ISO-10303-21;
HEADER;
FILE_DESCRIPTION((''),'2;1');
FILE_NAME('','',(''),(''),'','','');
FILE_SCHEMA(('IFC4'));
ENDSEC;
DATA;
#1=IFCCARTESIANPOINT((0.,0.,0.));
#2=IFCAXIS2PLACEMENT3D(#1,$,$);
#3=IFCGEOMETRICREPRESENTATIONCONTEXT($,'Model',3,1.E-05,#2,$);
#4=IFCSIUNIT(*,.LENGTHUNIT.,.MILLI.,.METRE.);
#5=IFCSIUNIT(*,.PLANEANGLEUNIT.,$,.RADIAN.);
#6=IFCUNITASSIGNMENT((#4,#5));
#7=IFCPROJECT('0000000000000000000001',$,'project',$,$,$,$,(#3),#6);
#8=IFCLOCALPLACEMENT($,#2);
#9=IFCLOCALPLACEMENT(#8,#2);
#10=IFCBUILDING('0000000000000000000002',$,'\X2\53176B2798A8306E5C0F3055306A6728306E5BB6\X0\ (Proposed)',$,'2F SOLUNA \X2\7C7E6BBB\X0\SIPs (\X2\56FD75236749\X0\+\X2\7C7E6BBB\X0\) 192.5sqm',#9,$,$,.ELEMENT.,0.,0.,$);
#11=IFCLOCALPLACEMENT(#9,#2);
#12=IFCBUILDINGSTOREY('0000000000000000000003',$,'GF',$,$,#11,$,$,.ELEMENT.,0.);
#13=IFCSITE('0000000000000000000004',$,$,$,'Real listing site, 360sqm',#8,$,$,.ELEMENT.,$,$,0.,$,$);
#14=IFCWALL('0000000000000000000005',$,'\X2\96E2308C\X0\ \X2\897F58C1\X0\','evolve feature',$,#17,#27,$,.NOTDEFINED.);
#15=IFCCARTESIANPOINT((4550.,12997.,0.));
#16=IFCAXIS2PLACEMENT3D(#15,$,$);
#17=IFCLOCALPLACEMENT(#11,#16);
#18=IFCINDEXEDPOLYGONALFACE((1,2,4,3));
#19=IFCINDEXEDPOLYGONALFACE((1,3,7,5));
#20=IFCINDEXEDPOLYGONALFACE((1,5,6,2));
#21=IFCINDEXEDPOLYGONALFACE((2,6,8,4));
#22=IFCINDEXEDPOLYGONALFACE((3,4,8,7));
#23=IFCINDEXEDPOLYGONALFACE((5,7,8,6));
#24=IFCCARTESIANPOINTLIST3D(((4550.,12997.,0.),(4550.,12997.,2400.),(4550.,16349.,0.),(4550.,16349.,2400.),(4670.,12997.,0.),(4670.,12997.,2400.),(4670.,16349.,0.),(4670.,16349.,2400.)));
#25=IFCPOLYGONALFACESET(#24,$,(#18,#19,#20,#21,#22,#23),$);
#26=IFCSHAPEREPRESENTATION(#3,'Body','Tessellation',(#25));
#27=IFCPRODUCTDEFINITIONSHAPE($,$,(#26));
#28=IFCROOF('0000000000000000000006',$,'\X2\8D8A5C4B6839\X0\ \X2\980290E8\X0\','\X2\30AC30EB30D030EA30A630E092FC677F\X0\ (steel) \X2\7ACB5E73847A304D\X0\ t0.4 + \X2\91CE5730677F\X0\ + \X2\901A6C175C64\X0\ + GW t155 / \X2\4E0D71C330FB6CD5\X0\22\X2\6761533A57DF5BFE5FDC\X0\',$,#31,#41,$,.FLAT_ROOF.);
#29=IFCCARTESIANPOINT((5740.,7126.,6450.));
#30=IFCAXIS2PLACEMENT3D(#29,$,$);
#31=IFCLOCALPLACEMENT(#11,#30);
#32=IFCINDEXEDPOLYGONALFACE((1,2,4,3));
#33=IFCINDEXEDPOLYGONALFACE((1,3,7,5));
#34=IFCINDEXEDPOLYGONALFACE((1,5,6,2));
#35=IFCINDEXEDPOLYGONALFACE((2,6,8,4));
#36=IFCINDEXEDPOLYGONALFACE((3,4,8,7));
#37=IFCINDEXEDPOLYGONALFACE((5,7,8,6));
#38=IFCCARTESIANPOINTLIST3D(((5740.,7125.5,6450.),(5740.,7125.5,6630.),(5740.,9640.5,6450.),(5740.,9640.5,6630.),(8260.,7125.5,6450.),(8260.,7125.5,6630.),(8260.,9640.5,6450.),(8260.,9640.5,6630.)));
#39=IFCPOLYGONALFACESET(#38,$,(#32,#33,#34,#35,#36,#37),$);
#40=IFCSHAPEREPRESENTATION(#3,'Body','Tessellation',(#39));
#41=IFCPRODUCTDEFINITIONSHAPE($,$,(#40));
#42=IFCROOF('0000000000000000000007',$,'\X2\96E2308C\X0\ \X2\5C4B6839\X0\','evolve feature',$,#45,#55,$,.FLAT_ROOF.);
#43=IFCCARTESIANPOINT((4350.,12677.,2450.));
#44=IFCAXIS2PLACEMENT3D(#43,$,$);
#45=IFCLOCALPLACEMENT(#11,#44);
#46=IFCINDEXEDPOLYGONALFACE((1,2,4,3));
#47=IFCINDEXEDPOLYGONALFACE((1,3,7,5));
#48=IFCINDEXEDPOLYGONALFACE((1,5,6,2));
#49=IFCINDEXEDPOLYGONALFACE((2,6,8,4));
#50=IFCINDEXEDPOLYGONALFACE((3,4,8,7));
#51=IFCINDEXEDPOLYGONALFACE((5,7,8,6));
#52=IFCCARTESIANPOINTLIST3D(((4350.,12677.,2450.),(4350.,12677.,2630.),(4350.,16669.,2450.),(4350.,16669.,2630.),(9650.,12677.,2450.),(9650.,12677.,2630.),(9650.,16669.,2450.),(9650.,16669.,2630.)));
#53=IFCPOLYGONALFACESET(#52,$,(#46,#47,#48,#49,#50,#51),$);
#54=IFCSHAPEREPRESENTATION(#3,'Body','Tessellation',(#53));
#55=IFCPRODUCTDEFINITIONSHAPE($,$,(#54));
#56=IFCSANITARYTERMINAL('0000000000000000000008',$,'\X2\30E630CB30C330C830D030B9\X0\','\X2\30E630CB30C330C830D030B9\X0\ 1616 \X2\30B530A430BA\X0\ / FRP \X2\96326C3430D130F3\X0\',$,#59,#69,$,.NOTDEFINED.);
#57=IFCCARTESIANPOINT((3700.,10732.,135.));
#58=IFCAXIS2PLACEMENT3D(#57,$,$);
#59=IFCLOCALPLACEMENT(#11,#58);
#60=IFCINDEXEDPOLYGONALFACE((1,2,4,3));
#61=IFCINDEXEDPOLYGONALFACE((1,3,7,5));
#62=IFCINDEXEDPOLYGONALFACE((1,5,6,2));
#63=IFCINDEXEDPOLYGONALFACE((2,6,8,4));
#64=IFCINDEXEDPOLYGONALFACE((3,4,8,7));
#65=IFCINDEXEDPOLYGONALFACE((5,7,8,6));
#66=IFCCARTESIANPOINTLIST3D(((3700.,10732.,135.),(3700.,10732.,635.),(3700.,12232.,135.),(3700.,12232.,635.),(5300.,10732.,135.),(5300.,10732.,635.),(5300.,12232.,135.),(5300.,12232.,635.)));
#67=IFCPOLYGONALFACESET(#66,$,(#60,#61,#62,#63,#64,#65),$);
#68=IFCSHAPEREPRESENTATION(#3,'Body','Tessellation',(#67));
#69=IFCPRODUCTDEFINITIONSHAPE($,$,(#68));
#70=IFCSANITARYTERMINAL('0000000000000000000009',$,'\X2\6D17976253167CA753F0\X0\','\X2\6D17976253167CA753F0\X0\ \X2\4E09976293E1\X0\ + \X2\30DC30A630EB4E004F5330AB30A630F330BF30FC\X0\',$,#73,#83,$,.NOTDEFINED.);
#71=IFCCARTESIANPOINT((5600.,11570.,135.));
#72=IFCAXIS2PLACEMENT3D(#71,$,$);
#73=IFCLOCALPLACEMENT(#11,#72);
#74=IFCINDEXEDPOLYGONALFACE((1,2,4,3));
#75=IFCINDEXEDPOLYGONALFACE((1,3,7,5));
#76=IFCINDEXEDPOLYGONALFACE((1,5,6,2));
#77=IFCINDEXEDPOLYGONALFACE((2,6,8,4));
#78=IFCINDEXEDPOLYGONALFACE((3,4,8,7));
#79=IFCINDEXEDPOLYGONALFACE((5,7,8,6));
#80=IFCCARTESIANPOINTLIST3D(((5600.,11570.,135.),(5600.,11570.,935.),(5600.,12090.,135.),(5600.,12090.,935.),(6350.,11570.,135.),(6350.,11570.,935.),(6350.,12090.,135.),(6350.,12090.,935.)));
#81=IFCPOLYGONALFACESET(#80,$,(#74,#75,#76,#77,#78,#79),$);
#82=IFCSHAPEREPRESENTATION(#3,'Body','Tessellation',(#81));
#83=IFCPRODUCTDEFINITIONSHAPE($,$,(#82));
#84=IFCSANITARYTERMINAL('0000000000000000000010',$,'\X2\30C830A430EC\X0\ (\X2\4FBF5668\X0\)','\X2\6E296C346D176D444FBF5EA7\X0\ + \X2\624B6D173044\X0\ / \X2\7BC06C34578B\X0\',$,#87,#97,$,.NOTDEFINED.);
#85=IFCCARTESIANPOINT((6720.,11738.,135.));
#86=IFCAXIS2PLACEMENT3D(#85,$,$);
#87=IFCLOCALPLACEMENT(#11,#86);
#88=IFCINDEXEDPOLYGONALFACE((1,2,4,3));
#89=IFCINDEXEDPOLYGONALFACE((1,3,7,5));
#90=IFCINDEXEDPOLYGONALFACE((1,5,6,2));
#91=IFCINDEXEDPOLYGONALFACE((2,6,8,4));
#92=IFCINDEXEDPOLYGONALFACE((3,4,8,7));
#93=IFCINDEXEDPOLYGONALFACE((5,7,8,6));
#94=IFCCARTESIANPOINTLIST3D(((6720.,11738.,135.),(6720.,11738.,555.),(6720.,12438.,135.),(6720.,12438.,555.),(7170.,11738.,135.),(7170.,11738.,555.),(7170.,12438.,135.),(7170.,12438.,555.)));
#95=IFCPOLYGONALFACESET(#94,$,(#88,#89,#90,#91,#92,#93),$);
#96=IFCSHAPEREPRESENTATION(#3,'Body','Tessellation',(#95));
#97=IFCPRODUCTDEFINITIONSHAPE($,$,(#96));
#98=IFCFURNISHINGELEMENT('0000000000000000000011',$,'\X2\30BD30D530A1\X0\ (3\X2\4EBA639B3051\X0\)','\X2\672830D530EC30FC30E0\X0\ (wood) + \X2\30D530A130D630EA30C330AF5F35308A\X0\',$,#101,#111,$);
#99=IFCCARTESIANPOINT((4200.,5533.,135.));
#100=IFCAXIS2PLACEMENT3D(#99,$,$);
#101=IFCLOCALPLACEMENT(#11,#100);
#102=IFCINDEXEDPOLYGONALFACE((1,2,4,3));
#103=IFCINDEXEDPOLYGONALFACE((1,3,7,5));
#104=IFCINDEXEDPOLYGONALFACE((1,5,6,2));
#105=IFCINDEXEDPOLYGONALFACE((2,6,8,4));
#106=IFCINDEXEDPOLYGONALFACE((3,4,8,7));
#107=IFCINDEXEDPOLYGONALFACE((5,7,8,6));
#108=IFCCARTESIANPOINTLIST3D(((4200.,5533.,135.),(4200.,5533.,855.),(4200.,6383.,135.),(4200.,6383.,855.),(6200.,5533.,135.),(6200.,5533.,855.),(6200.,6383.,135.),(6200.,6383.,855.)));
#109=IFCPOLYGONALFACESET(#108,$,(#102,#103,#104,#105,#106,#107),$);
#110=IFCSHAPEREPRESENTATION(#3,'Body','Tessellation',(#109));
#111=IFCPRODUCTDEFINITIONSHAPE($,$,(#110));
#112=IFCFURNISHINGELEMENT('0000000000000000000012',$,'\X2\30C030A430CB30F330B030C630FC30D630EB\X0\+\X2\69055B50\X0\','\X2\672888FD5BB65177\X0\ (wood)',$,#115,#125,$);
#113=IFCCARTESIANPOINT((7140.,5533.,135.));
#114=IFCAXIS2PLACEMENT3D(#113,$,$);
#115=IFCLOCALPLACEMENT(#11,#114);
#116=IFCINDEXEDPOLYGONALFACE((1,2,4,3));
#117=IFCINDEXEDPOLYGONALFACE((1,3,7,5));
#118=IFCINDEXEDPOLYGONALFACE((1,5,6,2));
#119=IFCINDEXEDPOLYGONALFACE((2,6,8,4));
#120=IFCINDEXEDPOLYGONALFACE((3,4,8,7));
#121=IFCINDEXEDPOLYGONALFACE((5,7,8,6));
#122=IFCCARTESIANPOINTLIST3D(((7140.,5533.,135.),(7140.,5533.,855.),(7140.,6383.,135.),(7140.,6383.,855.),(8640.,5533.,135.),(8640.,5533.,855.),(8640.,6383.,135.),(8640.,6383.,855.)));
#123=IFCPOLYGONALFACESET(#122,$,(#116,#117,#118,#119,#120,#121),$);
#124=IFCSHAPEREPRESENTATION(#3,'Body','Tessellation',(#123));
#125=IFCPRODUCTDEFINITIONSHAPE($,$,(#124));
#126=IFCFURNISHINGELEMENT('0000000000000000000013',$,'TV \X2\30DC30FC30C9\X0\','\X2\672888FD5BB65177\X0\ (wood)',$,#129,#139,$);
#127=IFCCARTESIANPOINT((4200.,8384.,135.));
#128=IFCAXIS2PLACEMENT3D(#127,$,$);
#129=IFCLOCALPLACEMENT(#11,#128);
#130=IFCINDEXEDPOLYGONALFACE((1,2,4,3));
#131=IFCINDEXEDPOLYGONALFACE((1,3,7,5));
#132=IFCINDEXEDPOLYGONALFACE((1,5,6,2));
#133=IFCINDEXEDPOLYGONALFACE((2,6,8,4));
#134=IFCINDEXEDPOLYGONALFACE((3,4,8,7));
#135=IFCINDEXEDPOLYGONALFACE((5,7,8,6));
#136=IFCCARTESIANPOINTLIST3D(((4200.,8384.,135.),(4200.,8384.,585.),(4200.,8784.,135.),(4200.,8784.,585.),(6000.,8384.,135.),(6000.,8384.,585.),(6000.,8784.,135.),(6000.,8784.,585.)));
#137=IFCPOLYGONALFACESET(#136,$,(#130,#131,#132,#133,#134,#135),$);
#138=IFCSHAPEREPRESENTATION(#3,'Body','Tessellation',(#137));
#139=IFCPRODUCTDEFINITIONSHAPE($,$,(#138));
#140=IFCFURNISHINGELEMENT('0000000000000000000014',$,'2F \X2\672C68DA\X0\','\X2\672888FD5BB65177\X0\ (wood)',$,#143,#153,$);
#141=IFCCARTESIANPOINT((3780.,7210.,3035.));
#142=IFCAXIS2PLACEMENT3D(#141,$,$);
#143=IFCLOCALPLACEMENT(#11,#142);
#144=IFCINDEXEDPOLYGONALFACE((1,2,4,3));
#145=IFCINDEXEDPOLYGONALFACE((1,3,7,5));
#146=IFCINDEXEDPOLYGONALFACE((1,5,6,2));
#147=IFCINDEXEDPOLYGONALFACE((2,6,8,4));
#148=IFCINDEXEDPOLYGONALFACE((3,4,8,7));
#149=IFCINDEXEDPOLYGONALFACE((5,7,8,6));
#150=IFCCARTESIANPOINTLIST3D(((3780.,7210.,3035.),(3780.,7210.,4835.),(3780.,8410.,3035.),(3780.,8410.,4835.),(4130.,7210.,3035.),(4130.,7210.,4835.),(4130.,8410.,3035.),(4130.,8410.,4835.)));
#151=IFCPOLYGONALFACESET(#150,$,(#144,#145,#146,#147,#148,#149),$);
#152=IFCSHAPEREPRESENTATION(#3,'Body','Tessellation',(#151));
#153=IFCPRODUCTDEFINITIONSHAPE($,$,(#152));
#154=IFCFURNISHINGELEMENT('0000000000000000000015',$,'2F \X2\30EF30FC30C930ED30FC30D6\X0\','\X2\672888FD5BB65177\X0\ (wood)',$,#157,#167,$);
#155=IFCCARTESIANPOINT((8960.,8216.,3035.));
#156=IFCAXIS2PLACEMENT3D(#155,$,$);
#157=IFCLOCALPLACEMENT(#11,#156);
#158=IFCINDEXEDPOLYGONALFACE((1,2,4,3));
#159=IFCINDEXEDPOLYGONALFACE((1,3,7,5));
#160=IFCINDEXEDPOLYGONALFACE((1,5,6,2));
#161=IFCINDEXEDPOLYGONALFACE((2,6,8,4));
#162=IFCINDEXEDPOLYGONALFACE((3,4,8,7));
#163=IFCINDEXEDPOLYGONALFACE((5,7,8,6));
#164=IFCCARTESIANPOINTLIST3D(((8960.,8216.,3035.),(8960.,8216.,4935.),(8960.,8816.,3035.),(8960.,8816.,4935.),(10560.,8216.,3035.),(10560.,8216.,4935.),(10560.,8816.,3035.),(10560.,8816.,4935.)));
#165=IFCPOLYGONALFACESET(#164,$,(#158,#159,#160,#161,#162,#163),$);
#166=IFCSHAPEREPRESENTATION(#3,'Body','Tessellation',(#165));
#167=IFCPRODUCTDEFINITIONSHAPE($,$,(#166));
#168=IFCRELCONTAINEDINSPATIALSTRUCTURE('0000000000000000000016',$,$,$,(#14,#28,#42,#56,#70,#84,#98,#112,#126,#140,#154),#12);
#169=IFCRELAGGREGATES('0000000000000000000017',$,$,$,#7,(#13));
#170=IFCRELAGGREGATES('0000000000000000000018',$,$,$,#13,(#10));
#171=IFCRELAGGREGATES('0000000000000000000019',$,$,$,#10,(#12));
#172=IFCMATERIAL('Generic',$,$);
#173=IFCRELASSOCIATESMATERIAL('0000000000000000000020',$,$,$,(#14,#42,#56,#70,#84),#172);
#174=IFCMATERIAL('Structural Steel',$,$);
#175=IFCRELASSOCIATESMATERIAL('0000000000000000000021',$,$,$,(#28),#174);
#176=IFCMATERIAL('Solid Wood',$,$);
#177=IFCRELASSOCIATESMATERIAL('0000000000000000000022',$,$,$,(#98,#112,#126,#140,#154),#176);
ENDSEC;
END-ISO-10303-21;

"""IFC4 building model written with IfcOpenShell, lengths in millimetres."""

from ifc_helpers import new_model, si_unit, frame, frame_2d, origin, place, context, project, spatial, rectangle, extrude, material, element, save


model = new_model("IFC4")

# Units and contexts
model_context = context("Model", 3, precision=1e-05, world=origin())
ifc_project = project(units=[si_unit("LENGTHUNIT", "METRE", prefix="MILLI"), si_unit("PLANEANGLEUNIT", "RADIAN")], contexts=[model_context])

# Site, building, storey
site_placement = place(None, origin())
site = spatial("IfcSite", under=ifc_project, at=site_placement, ObjectType="Real listing site, 360sqm", CompositionType="ELEMENT", RefElevation=0.0)
building_placement = place(site_placement, origin())
building = spatial("IfcBuilding", under=site, at=building_placement, Name="北欧風の小さな木の家 (Proposed)", ObjectType="2F SOLUNA 籾殻SIPs (国産杉+籾殻) 192.5sqm", CompositionType="ELEMENT", ElevationOfRefHeight=0.0, ElevationOfTerrain=0.0)
storey_placement = place(building_placement, origin())
storey = spatial("IfcBuildingStorey", under=building, at=storey_placement, Name="GF", CompositionType="ELEMENT", Elevation=0.0)

# Shared definitions
ifc_material_1 = material(Name="Generic")

# Shared definitions
ifc_material_2 = material(Name="Solid Wood")

# Wall
wall_1_placement = place(storey_placement, frame((4550.0, 12997.0, 0.0)))
element("IfcWall", 1, at=wall_1_placement, inside=storey, material=ifc_material_1, Name="離れ 西壁", Description="evolve feature", PredefinedType="NOTDEFINED", context=model_context, shape_type="SweptSolid", body=[
    extrude(rectangle(XDim=120.0, YDim=3352.0, at=frame_2d((60.0, 1676.0))), frame((4550.0, 12997.0, 0.0)), (0.0, 0.0, 1.0), 2400.0),
])

# Roofs
ifc_material_3 = material(Name="Structural Steel")
roof_1_placement = place(storey_placement, frame((5740.0, 7126.0, 6450.0)))
element("IfcRoof", 2, at=roof_1_placement, inside=storey, material=ifc_material_3, Name="越屋根 頂部", Description="ガルバリウム鋼板 (steel) 立平葺き t0.4 + 野地板 + 通気層 + GW t155 / 不燃・法22条区域対応", PredefinedType="FLAT_ROOF", context=model_context, shape_type="SweptSolid", body=[
    extrude(rectangle(XDim=2520.0, YDim=2515.0, at=frame_2d((1260.0, 1257.0))), frame((5740.0, 7126.0, 6450.0)), (0.0, 0.0, 1.0), 180.0),
])
roof_2_placement = place(storey_placement, frame((4350.0, 12677.0, 2450.0)))
element("IfcRoof", 3, at=roof_2_placement, inside=storey, material=ifc_material_1, Name="離れ 屋根", Description="evolve feature", PredefinedType="FLAT_ROOF", context=model_context, shape_type="SweptSolid", body=[
    extrude(rectangle(XDim=5300.0, YDim=3992.0, at=frame_2d((2650.0, 1996.0))), frame((4350.0, 12677.0, 2450.0)), (0.0, 0.0, 1.0), 180.0),
])

# Sanitary terminals
sanitary_terminal_1_placement = place(storey_placement, frame((3700.0, 10732.0, 135.0)))
element("IfcSanitaryTerminal", 4, at=sanitary_terminal_1_placement, inside=storey, material=ifc_material_1, Name="ユニットバス", Description="ユニットバス 1616 サイズ / FRP 防水パン", PredefinedType="NOTDEFINED", context=model_context, shape_type="SweptSolid", body=[
    extrude(rectangle(XDim=1600.0, YDim=1500.0, at=frame_2d((800.0, 750.0))), frame((3700.0, 10732.0, 135.0)), (0.0, 0.0, 1.0), 500.0),
])
sanitary_terminal_2_placement = place(storey_placement, frame((5600.0, 11570.0, 135.0)))
element("IfcSanitaryTerminal", 5, at=sanitary_terminal_2_placement, inside=storey, material=ifc_material_1, Name="洗面化粧台", Description="洗面化粧台 三面鏡 + ボウル一体カウンター", PredefinedType="NOTDEFINED", context=model_context, shape_type="SweptSolid", body=[
    extrude(rectangle(XDim=750.0, YDim=520.0, at=frame_2d((375.0, 260.0))), frame((5600.0, 11570.0, 135.0)), (0.0, 0.0, 1.0), 800.0),
])
sanitary_terminal_3_placement = place(storey_placement, frame((6720.0, 11738.0, 135.0)))
element("IfcSanitaryTerminal", 6, at=sanitary_terminal_3_placement, inside=storey, material=ifc_material_1, Name="トイレ (便器)", Description="温水洗浄便座 + 手洗い / 節水型", PredefinedType="NOTDEFINED", context=model_context, shape_type="SweptSolid", body=[
    extrude(rectangle(XDim=450.0, YDim=700.0, at=frame_2d((225.0, 350.0))), frame((6720.0, 11738.0, 135.0)), (0.0, 0.0, 1.0), 420.0),
])

# Furnishing elements
furnishing_1_placement = place(storey_placement, frame((4200.0, 5533.0, 135.0)))
element("IfcFurnishingElement", 7, at=furnishing_1_placement, inside=storey, material=ifc_material_2, Name="ソファ (3人掛け)", Description="木フレーム (wood) + ファブリック張り", context=model_context, shape_type="SweptSolid", body=[
    extrude(rectangle(XDim=2000.0, YDim=850.0, at=frame_2d((1000.0, 425.0))), frame((4200.0, 5533.0, 135.0)), (0.0, 0.0, 1.0), 720.0),
])
furnishing_2_placement = place(storey_placement, frame((7140.0, 5533.0, 135.0)))
element("IfcFurnishingElement", 8, at=furnishing_2_placement, inside=storey, material=ifc_material_2, Name="ダイニングテーブル+椅子", Description="木製家具 (wood)", context=model_context, shape_type="SweptSolid", body=[
    extrude(rectangle(XDim=1500.0, YDim=850.0, at=frame_2d((750.0, 425.0))), frame((7140.0, 5533.0, 135.0)), (0.0, 0.0, 1.0), 720.0),
])
furnishing_3_placement = place(storey_placement, frame((4200.0, 8384.0, 135.0)))
element("IfcFurnishingElement", 9, at=furnishing_3_placement, inside=storey, material=ifc_material_2, Name="TV ボード", Description="木製家具 (wood)", context=model_context, shape_type="SweptSolid", body=[
    extrude(rectangle(XDim=1800.0, YDim=400.0, at=frame_2d((900.0, 200.0))), frame((4200.0, 8384.0, 135.0)), (0.0, 0.0, 1.0), 450.0),
])
furnishing_4_placement = place(storey_placement, frame((3780.0, 7210.0, 3035.0)))
element("IfcFurnishingElement", 10, at=furnishing_4_placement, inside=storey, material=ifc_material_2, Name="2F 本棚", Description="木製家具 (wood)", context=model_context, shape_type="SweptSolid", body=[
    extrude(rectangle(XDim=350.0, YDim=1200.0, at=frame_2d((175.0, 600.0))), frame((3780.0, 7210.0, 3035.0)), (0.0, 0.0, 1.0), 1800.0),
])
furnishing_5_placement = place(storey_placement, frame((8960.0, 8216.0, 3035.0)))
element("IfcFurnishingElement", 11, at=furnishing_5_placement, inside=storey, material=ifc_material_2, Name="2F ワードローブ", Description="木製家具 (wood)", context=model_context, shape_type="SweptSolid", body=[
    extrude(rectangle(XDim=1600.0, YDim=600.0, at=frame_2d((800.0, 300.0))), frame((8960.0, 8216.0, 3035.0)), (0.0, 0.0, 1.0), 1900.0),
])

save(model, "model.ifc")
